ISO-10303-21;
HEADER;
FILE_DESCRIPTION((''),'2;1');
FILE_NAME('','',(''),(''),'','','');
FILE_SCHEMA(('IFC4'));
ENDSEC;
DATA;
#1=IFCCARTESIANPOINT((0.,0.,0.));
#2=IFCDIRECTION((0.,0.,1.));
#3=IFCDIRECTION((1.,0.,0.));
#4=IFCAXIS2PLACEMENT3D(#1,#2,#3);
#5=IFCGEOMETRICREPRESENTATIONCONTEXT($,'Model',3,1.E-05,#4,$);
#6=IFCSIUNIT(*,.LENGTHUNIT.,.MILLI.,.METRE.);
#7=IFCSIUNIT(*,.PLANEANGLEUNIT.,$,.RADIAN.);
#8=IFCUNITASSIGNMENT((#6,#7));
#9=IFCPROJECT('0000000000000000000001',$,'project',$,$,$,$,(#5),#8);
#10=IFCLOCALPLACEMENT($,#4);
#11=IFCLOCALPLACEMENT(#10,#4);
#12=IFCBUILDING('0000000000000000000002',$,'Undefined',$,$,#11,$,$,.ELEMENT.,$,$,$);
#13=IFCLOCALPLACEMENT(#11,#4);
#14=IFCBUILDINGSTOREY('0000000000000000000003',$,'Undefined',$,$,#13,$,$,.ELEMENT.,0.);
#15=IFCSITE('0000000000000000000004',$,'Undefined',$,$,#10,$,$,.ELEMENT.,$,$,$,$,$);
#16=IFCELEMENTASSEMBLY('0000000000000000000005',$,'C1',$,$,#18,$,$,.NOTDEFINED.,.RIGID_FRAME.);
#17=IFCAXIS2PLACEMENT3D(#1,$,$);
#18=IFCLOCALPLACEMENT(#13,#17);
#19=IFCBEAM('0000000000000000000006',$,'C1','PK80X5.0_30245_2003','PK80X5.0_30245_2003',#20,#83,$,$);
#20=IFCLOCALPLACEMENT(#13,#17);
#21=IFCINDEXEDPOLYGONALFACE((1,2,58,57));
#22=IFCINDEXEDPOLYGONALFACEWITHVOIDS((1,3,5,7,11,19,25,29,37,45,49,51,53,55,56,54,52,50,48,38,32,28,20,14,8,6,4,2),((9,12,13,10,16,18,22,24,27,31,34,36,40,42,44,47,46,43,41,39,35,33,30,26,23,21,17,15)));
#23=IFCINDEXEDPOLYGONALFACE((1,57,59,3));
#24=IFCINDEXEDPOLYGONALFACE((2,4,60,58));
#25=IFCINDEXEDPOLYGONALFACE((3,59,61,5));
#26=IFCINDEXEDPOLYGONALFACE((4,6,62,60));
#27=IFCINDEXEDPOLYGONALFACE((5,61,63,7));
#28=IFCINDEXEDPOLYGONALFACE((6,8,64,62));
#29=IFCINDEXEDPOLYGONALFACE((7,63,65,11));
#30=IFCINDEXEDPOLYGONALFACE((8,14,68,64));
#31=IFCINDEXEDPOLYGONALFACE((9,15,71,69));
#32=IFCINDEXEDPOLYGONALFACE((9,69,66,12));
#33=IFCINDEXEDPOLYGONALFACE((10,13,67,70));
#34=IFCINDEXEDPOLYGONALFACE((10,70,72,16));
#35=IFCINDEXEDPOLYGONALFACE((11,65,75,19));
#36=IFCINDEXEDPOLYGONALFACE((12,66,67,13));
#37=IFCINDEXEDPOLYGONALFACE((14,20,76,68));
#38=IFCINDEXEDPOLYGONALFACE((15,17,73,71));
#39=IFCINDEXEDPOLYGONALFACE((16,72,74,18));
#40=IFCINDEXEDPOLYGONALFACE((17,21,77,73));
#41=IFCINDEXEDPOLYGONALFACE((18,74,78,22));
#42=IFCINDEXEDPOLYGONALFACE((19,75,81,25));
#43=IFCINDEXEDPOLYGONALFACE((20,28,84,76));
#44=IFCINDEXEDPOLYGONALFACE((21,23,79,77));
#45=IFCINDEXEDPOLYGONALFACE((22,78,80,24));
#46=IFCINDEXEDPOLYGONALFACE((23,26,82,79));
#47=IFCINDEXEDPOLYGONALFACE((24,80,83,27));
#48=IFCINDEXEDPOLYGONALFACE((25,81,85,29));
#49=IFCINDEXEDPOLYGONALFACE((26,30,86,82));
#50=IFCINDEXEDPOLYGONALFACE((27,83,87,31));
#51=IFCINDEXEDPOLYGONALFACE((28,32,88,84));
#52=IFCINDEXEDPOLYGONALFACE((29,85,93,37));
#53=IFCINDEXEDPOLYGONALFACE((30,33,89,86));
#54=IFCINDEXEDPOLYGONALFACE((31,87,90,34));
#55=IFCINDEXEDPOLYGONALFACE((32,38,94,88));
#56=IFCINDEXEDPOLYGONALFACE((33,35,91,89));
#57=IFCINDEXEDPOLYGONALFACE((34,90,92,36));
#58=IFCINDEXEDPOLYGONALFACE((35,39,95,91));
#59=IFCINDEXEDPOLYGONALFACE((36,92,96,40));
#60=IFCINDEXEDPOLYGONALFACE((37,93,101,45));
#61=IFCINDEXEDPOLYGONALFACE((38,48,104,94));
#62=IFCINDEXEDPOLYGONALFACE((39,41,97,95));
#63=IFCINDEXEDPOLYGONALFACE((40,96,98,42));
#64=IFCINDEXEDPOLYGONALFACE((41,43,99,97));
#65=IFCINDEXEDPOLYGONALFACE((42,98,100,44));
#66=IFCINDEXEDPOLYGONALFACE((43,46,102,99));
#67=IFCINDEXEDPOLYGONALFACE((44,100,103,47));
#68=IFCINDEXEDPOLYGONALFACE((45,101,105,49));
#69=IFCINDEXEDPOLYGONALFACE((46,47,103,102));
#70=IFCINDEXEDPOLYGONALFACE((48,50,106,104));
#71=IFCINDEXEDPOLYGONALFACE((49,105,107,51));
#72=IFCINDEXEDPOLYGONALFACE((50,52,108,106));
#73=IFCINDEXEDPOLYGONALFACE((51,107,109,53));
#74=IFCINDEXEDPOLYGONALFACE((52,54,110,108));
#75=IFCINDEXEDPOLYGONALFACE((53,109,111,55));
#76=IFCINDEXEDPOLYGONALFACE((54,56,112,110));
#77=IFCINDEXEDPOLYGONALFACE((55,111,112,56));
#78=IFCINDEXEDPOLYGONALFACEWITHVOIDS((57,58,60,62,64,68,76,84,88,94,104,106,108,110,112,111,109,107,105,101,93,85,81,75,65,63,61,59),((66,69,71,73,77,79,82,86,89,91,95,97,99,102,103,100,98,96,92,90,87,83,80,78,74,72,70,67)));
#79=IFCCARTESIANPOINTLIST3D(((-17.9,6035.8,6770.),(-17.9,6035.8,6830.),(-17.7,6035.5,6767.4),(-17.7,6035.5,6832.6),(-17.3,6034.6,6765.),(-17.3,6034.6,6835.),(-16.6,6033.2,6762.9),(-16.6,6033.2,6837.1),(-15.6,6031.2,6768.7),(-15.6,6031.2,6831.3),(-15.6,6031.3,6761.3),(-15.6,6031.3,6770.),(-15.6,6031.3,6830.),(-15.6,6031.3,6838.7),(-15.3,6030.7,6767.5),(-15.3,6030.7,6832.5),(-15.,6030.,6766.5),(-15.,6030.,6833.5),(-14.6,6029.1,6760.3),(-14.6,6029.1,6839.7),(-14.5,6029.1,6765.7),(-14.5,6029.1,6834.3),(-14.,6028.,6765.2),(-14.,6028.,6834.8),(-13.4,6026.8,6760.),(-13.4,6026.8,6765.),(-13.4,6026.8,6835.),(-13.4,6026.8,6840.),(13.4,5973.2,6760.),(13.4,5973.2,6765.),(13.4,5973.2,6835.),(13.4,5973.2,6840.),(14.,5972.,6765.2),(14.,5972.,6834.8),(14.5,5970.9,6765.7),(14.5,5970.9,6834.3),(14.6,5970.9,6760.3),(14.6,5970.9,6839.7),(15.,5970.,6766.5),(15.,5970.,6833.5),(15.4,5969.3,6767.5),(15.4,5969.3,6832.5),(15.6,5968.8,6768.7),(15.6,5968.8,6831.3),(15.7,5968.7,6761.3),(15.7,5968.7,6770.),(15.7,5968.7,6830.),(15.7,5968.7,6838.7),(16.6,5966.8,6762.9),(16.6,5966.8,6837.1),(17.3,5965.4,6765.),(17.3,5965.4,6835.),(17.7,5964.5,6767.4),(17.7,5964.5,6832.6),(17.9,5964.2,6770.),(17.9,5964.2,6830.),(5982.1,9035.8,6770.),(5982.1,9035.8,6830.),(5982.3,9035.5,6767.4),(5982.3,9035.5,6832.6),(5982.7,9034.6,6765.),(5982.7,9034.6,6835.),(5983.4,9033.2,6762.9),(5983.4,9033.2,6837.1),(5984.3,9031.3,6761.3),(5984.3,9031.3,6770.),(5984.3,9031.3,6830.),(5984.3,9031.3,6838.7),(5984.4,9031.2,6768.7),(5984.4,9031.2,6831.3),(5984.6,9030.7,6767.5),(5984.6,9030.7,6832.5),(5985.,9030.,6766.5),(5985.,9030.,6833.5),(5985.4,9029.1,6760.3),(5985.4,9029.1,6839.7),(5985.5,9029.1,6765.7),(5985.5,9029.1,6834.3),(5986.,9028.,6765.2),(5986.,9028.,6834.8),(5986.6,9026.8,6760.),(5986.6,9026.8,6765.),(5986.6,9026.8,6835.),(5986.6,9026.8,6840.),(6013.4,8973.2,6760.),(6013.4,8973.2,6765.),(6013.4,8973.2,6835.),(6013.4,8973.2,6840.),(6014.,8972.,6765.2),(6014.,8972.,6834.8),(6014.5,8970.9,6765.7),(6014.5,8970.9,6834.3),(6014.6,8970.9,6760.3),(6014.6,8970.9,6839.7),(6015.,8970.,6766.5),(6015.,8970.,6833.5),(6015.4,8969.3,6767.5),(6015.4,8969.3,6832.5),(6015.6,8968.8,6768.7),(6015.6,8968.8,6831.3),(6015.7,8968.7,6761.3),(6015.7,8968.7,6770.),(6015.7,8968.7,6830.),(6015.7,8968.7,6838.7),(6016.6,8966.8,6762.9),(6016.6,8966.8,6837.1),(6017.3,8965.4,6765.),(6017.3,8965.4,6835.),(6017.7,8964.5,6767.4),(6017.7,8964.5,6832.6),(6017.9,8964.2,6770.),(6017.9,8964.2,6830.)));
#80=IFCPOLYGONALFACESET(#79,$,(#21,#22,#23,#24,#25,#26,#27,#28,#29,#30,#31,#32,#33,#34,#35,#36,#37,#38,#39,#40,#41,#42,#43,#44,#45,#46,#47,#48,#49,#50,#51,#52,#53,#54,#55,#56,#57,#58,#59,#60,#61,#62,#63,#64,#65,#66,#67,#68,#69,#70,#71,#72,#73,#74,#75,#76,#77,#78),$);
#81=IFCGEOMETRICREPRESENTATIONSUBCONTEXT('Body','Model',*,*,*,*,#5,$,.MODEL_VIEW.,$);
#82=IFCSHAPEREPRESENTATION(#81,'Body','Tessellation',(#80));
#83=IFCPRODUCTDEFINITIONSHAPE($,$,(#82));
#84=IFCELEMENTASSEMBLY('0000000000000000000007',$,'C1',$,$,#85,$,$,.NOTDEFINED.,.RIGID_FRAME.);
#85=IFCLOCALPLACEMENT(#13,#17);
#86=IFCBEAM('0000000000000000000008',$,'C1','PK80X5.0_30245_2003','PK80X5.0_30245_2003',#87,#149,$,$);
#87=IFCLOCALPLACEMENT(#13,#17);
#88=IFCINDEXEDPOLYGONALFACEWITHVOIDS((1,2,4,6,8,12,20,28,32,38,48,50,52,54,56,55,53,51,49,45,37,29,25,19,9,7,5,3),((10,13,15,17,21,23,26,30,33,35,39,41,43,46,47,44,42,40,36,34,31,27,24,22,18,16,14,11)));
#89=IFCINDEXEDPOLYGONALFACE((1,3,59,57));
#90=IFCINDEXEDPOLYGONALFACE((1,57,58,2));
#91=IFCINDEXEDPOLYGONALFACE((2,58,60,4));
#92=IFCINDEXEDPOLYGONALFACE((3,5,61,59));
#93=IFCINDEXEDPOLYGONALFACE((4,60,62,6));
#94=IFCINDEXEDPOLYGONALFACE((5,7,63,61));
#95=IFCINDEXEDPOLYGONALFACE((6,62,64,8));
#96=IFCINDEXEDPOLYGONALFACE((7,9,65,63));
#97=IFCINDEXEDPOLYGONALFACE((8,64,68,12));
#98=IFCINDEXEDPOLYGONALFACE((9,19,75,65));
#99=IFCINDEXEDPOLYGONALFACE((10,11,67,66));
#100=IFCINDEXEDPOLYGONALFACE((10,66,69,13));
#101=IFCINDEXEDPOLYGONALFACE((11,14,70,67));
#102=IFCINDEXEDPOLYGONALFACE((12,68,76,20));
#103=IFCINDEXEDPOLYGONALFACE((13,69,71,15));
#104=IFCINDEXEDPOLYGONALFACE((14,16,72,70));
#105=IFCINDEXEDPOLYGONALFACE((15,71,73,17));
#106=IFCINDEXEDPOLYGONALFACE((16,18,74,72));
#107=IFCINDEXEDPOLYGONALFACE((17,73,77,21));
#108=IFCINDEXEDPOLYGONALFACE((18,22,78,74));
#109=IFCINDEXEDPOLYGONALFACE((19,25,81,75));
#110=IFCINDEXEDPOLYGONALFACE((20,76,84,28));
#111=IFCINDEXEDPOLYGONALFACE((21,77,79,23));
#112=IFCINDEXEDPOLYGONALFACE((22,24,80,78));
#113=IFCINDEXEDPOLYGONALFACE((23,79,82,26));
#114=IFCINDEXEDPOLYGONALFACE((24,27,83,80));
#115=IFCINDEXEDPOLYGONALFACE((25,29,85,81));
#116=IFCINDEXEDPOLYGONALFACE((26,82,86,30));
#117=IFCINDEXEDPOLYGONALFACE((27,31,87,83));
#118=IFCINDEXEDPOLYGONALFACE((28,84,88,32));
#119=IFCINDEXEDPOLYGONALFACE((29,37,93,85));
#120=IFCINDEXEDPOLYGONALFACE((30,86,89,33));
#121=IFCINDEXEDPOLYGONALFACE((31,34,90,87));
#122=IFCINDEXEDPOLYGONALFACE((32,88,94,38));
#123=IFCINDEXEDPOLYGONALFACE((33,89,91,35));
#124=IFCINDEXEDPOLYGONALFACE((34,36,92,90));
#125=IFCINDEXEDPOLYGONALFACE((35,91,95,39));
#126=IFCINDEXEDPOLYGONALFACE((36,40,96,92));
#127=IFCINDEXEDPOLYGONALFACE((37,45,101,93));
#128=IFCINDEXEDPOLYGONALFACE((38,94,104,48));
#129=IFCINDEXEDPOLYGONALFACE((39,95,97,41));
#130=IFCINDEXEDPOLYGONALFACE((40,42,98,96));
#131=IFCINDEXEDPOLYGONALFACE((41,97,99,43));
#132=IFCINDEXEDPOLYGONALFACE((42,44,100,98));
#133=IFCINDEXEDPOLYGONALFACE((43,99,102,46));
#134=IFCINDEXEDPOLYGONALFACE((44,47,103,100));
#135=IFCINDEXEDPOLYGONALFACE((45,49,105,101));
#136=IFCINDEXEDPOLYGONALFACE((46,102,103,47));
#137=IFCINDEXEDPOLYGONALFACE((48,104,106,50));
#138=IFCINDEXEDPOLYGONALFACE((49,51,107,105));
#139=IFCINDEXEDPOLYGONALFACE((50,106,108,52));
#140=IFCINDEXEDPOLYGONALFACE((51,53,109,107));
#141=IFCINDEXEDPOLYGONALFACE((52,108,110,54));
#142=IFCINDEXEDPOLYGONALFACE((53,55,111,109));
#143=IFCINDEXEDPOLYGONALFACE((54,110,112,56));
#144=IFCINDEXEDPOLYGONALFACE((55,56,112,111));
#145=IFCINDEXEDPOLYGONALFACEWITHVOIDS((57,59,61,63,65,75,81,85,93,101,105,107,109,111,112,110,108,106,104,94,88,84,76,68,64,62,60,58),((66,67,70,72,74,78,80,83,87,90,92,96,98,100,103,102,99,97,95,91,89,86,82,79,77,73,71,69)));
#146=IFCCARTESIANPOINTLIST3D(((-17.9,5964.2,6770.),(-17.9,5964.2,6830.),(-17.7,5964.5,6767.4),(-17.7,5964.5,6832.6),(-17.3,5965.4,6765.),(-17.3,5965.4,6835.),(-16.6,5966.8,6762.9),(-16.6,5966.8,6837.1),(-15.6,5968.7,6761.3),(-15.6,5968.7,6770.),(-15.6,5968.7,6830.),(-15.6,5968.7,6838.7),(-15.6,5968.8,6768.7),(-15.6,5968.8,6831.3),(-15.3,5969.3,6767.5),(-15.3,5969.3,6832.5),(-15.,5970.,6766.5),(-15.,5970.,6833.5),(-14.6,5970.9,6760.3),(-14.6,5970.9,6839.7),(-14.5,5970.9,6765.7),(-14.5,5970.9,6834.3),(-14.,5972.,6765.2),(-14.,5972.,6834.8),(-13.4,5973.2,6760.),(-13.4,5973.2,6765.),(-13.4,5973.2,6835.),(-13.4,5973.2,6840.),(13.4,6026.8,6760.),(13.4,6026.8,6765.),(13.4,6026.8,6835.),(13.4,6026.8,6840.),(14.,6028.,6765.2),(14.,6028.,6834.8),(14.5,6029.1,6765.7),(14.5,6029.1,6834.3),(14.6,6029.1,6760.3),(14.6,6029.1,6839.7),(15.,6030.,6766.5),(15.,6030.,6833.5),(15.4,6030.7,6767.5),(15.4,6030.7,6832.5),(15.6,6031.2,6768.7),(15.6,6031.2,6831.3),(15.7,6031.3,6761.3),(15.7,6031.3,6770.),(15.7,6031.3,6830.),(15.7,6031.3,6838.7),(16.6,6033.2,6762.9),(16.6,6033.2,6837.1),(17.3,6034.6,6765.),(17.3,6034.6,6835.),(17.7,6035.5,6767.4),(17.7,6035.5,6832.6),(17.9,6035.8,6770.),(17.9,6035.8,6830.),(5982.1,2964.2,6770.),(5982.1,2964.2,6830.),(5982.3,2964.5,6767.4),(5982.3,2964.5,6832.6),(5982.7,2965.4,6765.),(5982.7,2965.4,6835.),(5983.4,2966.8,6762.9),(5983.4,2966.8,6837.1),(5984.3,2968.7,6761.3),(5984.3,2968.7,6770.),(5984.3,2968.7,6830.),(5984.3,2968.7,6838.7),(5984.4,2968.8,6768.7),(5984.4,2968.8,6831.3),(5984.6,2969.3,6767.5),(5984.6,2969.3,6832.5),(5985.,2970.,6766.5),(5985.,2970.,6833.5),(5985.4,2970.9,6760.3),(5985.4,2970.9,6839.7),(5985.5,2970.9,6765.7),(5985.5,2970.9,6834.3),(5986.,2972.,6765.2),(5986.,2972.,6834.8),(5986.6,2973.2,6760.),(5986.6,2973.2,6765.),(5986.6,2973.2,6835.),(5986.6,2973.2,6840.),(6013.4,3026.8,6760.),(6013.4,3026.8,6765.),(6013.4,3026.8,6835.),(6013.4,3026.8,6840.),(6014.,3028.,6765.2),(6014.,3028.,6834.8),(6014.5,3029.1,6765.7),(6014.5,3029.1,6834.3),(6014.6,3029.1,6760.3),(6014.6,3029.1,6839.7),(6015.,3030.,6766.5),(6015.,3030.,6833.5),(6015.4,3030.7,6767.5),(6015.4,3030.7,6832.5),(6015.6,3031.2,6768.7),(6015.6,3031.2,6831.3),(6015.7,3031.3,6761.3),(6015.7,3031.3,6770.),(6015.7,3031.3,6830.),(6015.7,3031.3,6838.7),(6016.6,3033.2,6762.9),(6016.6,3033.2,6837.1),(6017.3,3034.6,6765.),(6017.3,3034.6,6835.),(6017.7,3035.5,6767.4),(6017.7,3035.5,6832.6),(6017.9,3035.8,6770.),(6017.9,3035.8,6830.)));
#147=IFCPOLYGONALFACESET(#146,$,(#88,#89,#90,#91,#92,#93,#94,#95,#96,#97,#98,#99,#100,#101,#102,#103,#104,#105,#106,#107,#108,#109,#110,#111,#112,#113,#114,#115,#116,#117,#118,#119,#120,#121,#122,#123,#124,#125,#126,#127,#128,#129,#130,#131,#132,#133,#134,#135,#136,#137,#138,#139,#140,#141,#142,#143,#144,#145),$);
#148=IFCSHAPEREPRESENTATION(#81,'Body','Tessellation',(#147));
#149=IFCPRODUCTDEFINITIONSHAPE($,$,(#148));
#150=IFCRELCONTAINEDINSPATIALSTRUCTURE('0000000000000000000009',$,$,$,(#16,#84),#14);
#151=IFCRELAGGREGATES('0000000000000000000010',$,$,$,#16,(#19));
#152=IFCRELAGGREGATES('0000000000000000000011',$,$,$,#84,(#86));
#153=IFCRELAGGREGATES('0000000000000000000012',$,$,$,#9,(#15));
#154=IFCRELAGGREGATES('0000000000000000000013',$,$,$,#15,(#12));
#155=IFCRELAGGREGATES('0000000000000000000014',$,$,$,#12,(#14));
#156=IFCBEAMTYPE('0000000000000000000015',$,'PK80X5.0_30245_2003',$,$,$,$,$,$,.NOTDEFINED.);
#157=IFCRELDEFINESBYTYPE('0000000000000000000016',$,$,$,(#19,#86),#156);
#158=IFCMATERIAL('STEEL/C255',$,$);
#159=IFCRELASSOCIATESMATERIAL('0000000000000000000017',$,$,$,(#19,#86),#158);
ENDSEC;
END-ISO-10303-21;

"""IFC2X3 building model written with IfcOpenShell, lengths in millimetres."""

from ifc_helpers import new_model, si_unit, frame, origin_with_axes, origin_2d_with_axis, place, context, subcontext, project, spatial, hollow_rectangle, extrude, material, type_object, element, aggregate, save


model = new_model("IFC2X3")

# Units and contexts
model_context = context("Model", 3, precision=1e-05, world=origin_with_axes())
body_context = subcontext(model_context, "Body", "Model", "MODEL_VIEW")
ifc_project = project(units=[si_unit("LENGTHUNIT", "METRE", prefix="MILLI"), si_unit("PLANEANGLEUNIT", "RADIAN")], contexts=[model_context])

# Site, building, storey
site_placement = place(None, origin_with_axes())
site = spatial("IfcSite", under=ifc_project, at=site_placement, Name="Undefined", CompositionType="ELEMENT")
building_placement = place(site_placement, origin_with_axes())
building = spatial("IfcBuilding", under=site, at=building_placement, Name="Undefined", CompositionType="ELEMENT")
storey_placement = place(building_placement, origin_with_axes())
storey = spatial("IfcBuildingStorey", under=building, at=storey_placement, Name="Undefined", CompositionType="ELEMENT", Elevation=0.0)

# Element assemblies, beams
assembly_1_placement = place(storey_placement, origin_with_axes())
assembly_1 = element("IfcElementAssembly", 1, at=assembly_1_placement, inside=storey, Name="C1", AssemblyPlace="NOTDEFINED", PredefinedType="RIGID_FRAME")
ifc_material_1 = material(Name="STEEL/C255")
beam_type_1 = type_object("IfcBeamType", Name="PK80X5.0_30245_2003", PredefinedType="NOTDEFINED")
beam_1_placement = place(assembly_1_placement, frame((0.0, 6000.0, 6800.0), z_axis=(0.0, 0.0, -1.0), x_axis=(0.894427, 0.447214, 0.0)))
beam_1 = element("IfcBeam", 2, at=beam_1_placement, type_object=beam_type_1, material=ifc_material_1, Name="C1", Description="PK80X5.0_30245_2003", ObjectType="PK80X5.0_30245_2003", context=body_context, shape_type="SweptSolid", body=[
    extrude(hollow_rectangle(XDim=80.0, YDim=80.0, WallThickness=5.0, InnerFilletRadius=5.0, OuterFilletRadius=10.0, at=origin_2d_with_axis()), frame((6708.2, 0.0, 0.0), z_axis=(-1.0, 0.0, 0.0), x_axis=(0.0, -1.0, 0.0)), (0.0, 0.0, 1.0), 6708.2),
])
aggregate(assembly_1, [beam_1])
assembly_2_placement = place(storey_placement, origin_with_axes())
assembly_2 = element("IfcElementAssembly", 3, at=assembly_2_placement, inside=storey, Name="C1", AssemblyPlace="NOTDEFINED", PredefinedType="RIGID_FRAME")
beam_2_placement = place(assembly_2_placement, frame((0.0, 6000.0, 6800.0), z_axis=(0.0, 0.0, -1.0), x_axis=(0.894427, -0.447214, 0.0)))
beam_2 = element("IfcBeam", 4, at=beam_2_placement, type_object=beam_type_1, material=ifc_material_1, Name="C1", Description="PK80X5.0_30245_2003", ObjectType="PK80X5.0_30245_2003", context=body_context, shape_type="SweptSolid", body=[
    extrude(hollow_rectangle(XDim=80.0, YDim=80.0, WallThickness=5.0, InnerFilletRadius=5.0, OuterFilletRadius=10.0, at=origin_2d_with_axis()), frame((6708.2, 0.0, 0.0), z_axis=(-1.0, 0.0, 0.0), x_axis=(0.0, -1.0, 0.0)), (0.0, 0.0, 1.0), 6708.2),
])
aggregate(assembly_2, [beam_2])

save(model, "model.ifc")
